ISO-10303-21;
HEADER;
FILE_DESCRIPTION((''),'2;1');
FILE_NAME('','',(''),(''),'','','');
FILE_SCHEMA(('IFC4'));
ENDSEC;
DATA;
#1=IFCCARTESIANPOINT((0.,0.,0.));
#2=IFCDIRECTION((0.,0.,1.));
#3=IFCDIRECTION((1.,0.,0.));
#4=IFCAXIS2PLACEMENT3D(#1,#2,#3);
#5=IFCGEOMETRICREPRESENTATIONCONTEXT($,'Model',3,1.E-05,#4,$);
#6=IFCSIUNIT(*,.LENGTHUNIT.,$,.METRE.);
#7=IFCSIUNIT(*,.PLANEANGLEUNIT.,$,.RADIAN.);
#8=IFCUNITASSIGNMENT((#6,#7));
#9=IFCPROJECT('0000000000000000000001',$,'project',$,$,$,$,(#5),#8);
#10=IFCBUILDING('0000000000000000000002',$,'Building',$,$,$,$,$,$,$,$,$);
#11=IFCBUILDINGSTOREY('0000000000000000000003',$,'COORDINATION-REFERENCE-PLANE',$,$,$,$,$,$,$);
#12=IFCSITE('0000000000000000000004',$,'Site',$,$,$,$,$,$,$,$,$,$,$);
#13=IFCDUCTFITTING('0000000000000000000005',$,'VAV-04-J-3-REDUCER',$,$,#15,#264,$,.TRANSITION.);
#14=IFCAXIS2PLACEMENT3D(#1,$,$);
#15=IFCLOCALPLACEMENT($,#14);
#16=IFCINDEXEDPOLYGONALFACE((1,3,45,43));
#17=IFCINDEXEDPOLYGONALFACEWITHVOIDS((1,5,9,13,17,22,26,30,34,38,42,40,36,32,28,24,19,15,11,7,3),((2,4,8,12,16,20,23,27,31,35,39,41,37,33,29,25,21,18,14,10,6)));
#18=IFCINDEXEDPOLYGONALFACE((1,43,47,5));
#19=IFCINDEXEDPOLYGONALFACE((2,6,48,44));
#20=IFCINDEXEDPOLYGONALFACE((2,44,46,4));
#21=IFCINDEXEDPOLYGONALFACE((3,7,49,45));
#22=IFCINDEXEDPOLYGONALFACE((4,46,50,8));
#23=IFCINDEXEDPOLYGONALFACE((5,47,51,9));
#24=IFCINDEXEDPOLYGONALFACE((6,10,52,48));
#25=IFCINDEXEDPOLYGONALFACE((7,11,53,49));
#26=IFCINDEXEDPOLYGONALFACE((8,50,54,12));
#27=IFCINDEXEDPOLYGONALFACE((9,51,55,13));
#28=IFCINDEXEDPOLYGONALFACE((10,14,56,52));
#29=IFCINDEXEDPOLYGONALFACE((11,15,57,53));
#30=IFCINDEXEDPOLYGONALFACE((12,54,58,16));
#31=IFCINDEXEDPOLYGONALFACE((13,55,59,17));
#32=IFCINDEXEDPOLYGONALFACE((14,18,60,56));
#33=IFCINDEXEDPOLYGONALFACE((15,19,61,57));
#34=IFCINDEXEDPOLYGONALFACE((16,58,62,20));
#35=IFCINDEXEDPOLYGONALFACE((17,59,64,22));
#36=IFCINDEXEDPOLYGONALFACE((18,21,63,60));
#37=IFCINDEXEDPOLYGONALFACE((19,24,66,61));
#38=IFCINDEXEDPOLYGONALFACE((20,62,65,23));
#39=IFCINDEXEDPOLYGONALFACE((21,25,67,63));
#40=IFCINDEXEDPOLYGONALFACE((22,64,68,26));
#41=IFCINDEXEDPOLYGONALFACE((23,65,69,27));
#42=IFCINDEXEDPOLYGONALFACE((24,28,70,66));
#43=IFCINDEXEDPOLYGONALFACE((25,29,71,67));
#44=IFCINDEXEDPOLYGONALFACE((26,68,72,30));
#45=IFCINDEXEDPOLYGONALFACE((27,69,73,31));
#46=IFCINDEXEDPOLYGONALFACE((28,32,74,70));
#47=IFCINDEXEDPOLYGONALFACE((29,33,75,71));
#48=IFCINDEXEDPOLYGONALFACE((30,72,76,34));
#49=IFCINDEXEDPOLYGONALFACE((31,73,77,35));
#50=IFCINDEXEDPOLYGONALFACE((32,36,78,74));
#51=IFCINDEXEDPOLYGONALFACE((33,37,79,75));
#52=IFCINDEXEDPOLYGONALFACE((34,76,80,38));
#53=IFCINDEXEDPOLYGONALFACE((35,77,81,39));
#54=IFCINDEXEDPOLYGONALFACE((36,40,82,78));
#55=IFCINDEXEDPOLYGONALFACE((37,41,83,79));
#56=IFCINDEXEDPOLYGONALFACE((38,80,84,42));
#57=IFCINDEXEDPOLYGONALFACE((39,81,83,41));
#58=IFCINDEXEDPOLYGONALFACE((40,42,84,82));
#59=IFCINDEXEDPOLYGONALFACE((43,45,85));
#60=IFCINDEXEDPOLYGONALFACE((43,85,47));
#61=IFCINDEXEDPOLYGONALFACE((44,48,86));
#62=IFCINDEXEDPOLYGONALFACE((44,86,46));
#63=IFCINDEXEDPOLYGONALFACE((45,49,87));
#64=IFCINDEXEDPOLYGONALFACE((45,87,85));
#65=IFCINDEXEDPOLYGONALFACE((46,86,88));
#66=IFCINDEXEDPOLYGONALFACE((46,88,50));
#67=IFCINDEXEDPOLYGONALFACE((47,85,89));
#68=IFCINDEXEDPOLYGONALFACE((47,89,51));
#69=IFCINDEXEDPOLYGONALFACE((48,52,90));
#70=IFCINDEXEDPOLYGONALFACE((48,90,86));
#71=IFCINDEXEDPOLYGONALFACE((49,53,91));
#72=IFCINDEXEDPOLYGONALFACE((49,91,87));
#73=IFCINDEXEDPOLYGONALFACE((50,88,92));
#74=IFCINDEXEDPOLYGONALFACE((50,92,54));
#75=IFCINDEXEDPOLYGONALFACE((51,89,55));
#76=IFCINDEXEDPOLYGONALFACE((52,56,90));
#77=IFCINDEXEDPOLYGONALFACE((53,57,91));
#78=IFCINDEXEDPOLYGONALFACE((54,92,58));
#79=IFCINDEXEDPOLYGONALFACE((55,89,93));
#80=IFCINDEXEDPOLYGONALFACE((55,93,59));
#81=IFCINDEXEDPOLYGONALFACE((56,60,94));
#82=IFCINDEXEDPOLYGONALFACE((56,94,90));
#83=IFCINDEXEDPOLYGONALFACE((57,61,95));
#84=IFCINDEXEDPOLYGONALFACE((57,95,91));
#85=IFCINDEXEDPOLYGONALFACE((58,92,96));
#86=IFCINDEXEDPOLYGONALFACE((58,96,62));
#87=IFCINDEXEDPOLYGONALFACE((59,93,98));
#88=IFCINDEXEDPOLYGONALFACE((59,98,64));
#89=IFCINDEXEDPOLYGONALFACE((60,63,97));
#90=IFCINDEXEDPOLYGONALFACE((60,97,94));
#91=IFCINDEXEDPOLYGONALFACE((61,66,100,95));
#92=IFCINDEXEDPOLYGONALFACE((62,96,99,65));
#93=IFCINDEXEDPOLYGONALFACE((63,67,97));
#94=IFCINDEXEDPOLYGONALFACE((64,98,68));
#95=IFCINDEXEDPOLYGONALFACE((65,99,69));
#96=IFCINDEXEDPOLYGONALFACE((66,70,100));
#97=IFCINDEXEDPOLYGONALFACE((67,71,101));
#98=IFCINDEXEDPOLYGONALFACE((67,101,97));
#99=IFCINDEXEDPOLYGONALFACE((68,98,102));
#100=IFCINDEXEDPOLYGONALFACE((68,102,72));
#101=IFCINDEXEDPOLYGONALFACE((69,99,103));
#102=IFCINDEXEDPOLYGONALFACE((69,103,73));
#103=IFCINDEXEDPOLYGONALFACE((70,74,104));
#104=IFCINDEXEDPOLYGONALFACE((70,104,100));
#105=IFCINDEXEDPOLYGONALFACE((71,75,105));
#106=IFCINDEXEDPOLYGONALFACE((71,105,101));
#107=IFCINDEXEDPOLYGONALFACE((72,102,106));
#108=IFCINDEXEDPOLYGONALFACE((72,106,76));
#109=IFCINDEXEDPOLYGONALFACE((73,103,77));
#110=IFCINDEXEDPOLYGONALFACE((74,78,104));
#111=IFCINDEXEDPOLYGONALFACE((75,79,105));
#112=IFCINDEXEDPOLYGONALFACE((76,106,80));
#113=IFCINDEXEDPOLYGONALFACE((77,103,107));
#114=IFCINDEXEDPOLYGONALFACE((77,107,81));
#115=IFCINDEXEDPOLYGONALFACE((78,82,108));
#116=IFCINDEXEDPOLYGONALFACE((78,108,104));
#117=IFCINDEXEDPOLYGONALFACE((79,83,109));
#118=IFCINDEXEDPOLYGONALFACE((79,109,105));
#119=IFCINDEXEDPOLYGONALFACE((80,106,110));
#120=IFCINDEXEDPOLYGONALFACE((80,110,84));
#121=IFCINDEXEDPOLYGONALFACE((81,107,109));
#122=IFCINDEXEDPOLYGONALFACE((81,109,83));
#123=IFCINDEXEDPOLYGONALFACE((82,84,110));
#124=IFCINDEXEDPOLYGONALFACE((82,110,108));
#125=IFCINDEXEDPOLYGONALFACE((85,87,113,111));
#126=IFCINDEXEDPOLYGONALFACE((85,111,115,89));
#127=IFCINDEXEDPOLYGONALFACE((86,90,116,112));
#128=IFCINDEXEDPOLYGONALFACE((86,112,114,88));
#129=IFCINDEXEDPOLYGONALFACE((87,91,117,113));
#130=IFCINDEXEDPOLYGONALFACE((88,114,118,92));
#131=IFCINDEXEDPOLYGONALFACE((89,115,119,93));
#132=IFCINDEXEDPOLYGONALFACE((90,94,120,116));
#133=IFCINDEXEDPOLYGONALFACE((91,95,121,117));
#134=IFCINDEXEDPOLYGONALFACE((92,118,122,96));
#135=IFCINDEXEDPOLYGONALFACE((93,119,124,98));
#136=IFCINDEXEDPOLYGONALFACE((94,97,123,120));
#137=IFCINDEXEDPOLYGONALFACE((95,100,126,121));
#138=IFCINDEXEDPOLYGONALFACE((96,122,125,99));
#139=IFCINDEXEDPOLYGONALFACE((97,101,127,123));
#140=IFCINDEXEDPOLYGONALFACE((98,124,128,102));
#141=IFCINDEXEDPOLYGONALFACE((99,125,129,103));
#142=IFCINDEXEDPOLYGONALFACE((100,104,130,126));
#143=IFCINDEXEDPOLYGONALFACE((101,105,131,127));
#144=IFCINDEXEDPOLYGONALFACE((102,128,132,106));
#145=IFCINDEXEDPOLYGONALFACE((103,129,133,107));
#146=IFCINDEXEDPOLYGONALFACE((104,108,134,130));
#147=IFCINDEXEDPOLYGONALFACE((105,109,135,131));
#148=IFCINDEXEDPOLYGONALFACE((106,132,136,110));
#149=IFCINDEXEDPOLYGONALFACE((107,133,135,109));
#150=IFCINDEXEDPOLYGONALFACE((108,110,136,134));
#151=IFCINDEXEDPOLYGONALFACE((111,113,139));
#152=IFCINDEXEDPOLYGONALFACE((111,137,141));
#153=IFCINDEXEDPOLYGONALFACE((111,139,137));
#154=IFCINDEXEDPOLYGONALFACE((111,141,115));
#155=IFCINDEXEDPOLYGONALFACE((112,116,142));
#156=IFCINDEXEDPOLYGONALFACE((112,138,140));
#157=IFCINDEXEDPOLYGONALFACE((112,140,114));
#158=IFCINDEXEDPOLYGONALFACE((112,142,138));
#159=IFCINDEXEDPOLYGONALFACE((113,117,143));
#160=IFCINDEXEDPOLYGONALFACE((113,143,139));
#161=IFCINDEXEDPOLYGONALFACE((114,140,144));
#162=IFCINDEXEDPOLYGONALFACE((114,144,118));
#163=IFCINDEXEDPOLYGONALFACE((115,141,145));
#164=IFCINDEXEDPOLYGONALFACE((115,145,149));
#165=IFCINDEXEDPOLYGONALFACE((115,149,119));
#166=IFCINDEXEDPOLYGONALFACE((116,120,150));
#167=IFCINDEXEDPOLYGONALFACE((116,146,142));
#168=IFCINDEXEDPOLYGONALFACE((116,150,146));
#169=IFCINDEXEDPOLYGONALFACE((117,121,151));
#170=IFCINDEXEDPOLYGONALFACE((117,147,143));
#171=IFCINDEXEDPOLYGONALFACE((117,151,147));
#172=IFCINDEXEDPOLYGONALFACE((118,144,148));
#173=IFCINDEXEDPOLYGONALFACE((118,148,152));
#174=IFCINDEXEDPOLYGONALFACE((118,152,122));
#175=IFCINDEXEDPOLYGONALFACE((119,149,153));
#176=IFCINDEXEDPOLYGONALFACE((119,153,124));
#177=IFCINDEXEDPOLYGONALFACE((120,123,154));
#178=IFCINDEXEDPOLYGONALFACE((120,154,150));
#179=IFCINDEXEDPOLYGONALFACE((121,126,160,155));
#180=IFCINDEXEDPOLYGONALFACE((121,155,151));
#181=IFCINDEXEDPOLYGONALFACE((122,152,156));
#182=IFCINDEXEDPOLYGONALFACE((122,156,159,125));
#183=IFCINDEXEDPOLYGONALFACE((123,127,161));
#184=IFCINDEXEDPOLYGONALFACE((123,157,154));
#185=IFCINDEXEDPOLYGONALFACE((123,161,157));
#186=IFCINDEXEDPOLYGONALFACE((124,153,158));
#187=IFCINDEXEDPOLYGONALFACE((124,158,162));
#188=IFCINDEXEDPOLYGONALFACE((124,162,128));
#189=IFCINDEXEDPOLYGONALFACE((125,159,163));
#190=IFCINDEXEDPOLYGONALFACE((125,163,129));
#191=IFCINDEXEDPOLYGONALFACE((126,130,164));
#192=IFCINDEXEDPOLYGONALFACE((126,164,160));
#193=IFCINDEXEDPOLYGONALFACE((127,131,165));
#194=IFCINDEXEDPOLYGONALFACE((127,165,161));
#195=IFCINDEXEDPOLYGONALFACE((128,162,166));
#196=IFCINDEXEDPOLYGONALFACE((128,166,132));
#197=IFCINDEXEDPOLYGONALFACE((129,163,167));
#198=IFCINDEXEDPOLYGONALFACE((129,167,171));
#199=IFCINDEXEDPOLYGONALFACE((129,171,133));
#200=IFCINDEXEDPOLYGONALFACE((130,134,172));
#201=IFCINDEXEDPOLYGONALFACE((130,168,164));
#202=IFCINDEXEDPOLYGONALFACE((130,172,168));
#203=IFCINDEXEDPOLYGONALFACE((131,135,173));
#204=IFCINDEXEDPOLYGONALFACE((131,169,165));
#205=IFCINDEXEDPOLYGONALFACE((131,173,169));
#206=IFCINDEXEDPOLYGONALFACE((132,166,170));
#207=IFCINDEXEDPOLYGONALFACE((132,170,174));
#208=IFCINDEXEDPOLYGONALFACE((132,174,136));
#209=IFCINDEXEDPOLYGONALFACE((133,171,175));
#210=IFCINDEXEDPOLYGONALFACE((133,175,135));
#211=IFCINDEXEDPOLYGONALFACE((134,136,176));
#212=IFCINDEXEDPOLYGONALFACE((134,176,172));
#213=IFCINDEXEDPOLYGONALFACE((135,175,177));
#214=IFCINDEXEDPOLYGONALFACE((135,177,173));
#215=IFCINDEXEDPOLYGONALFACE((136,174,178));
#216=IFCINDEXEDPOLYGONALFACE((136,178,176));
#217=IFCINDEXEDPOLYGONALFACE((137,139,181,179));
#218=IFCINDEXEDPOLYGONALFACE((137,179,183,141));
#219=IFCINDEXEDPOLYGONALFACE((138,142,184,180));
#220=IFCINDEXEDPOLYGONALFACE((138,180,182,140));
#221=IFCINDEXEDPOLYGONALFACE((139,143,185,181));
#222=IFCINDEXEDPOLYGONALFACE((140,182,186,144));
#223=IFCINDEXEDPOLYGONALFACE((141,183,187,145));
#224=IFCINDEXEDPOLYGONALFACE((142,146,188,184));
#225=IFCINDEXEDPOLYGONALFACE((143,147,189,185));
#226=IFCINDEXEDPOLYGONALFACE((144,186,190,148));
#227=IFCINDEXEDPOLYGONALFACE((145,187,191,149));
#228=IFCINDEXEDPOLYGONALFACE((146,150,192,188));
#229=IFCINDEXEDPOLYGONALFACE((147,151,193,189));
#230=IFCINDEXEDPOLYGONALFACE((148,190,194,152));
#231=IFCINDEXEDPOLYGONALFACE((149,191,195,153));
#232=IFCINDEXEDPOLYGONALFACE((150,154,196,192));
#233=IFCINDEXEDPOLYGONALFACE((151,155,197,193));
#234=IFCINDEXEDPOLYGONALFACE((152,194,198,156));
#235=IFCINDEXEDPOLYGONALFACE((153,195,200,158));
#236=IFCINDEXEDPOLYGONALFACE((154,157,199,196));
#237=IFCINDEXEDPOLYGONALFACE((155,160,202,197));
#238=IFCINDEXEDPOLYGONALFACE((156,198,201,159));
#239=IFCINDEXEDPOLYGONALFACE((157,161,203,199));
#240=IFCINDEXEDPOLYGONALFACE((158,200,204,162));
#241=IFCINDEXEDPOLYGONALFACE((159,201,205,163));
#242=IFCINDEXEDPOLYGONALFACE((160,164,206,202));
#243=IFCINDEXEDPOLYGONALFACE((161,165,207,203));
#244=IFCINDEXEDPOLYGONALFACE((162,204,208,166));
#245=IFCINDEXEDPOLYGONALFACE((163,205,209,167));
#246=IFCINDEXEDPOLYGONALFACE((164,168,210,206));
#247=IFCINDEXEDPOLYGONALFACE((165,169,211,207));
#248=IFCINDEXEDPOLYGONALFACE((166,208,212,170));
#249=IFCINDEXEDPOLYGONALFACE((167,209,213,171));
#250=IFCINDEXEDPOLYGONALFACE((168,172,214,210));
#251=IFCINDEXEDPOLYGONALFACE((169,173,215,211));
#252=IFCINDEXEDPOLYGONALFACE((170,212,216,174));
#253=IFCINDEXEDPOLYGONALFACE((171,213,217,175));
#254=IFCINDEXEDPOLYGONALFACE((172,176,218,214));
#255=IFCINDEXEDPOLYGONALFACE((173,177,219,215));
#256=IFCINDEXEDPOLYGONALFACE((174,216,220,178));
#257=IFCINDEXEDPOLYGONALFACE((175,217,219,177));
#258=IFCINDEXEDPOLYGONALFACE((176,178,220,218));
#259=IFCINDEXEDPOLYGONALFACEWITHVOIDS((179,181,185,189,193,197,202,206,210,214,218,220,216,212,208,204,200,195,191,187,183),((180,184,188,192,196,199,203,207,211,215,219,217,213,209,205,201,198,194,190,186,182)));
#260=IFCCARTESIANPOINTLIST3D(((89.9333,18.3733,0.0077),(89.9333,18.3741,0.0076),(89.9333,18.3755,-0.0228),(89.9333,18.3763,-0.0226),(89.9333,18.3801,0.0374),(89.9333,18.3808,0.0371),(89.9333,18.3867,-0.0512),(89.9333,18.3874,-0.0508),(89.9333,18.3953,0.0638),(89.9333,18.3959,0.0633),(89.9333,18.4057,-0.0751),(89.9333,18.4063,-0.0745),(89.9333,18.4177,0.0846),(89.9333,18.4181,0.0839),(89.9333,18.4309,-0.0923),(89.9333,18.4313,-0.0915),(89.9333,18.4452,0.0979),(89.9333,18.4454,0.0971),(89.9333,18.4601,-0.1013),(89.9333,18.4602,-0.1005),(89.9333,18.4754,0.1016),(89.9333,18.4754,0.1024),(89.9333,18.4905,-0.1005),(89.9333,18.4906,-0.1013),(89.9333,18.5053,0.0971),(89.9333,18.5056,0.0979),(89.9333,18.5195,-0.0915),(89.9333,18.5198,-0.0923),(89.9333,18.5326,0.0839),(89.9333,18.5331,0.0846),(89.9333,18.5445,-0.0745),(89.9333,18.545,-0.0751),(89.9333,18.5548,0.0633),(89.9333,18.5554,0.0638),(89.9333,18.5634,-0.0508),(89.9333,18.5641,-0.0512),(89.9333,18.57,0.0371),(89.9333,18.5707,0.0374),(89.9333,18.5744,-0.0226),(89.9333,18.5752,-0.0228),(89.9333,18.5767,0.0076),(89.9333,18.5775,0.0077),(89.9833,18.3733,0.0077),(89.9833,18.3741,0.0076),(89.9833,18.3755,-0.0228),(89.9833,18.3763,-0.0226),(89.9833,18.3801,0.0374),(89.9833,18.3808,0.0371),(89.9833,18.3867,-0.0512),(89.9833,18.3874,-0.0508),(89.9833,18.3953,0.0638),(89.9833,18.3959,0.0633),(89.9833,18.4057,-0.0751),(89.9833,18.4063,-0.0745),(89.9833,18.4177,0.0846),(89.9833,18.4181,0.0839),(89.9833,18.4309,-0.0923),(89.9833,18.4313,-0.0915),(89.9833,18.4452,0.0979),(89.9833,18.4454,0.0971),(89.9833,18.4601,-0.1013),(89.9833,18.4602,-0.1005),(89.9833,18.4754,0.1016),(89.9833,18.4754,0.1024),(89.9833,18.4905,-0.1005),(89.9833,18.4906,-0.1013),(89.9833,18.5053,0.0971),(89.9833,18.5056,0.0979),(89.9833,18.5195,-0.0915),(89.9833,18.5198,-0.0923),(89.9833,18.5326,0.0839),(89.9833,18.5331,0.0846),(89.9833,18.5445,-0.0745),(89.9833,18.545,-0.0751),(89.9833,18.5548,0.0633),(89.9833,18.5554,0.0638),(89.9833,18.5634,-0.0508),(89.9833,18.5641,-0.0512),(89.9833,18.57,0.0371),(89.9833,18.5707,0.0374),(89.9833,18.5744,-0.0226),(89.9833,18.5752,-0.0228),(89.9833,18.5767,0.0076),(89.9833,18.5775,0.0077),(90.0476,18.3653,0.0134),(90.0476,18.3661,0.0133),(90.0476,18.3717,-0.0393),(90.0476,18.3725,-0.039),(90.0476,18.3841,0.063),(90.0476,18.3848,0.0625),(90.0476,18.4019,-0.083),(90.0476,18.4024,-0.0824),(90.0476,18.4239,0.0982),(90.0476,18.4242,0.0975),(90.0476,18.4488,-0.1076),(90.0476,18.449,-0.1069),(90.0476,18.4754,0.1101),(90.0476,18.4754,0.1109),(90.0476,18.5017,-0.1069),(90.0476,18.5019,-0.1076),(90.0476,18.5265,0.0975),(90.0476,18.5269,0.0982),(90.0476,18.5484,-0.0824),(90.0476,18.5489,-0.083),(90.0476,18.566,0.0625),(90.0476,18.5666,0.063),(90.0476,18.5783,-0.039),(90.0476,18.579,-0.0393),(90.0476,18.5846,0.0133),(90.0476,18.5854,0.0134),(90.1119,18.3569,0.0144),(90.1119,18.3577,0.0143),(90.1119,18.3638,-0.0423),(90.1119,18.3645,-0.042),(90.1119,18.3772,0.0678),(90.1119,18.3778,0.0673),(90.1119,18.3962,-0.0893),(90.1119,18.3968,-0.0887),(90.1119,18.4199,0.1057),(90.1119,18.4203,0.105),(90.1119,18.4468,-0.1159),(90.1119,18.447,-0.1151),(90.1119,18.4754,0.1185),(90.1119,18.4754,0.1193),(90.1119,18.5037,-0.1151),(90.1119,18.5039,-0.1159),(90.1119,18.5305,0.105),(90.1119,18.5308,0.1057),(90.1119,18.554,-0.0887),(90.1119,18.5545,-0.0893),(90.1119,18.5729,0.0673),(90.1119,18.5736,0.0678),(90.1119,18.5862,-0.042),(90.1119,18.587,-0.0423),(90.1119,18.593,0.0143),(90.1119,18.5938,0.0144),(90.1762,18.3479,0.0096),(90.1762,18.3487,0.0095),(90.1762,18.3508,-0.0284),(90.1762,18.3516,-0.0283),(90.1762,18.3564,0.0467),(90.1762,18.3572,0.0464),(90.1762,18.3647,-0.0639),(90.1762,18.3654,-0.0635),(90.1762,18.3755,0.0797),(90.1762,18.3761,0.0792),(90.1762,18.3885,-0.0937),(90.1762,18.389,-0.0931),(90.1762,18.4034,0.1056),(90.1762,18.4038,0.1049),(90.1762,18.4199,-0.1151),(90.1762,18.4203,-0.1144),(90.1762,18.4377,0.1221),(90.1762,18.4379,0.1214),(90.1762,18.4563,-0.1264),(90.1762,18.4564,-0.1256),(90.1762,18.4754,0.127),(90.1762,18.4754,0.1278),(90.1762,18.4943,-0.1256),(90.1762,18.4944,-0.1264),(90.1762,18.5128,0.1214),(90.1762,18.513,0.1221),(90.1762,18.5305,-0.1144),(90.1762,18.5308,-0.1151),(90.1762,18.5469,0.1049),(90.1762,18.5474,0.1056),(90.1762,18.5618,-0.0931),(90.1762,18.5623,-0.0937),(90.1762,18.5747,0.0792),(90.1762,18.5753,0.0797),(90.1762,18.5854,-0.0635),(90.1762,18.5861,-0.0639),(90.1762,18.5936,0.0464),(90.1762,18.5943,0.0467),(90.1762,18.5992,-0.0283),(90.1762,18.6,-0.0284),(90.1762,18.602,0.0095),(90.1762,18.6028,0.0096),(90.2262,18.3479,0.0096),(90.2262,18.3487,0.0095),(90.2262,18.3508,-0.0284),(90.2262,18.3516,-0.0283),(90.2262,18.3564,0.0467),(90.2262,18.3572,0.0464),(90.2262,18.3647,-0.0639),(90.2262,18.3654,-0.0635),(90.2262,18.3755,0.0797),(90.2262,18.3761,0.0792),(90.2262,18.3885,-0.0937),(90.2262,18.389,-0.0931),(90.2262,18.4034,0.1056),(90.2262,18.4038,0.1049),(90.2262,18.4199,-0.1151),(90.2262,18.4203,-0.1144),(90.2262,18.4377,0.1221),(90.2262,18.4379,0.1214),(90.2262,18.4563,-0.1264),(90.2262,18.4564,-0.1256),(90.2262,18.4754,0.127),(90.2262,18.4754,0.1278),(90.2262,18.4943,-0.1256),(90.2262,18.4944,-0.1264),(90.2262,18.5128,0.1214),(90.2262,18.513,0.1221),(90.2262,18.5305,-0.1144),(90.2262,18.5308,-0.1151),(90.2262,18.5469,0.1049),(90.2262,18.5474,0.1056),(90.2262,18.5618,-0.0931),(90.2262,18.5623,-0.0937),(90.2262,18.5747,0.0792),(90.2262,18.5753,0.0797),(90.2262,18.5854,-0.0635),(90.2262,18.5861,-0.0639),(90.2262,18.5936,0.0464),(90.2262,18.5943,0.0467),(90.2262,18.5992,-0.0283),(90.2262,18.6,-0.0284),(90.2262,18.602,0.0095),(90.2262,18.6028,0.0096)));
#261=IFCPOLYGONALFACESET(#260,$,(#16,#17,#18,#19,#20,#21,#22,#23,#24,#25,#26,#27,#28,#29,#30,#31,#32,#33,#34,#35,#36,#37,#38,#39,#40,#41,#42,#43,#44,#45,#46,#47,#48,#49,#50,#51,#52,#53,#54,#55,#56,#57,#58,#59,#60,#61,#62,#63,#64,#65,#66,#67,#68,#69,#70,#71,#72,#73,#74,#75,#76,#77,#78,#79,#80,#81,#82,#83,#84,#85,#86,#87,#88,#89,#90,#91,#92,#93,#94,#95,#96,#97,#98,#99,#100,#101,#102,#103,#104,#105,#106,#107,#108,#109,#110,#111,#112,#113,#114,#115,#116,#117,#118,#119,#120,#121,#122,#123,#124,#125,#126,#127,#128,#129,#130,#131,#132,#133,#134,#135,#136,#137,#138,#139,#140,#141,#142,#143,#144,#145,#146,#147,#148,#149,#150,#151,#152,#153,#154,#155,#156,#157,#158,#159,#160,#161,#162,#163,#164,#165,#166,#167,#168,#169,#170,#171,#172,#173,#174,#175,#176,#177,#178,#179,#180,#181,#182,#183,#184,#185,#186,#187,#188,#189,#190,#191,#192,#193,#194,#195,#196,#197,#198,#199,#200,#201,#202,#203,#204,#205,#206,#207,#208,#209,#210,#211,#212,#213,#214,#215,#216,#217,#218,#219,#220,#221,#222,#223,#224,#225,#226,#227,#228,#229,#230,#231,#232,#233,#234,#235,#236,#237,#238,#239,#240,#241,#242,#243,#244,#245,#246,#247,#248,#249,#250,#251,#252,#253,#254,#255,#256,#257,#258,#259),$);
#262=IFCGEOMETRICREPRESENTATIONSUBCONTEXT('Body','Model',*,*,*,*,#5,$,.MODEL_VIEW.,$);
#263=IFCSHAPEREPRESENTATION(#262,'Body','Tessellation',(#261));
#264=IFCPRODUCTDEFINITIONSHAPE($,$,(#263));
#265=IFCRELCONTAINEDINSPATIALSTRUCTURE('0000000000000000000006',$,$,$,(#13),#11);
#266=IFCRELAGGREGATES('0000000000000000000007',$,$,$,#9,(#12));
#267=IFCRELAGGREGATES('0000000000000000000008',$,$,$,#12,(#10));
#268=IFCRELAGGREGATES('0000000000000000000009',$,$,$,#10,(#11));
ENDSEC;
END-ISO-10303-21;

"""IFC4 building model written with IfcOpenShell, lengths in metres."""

from ifc_helpers import new_model, entity, si_unit, frame, origin_with_axes, place, context, subcontext, project, spatial, element, save


model = new_model("IFC4")

# Units and contexts
model_context = context("Model", 3, precision=1e-05, world=origin_with_axes())
body_context_1 = subcontext(model_context, "Body", "Model", "MODEL_VIEW")
ifc_project = project(units=[si_unit("LENGTHUNIT", "METRE"), si_unit("PLANEANGLEUNIT", "RADIAN")], contexts=[model_context])

# Site, building, storey
site = spatial("IfcSite", under=ifc_project, Name="Site")
building = spatial("IfcBuilding", under=site, Name="Building")
storey = spatial("IfcBuildingStorey", under=building, Name="COORDINATION-REFERENCE-PLANE")

# Duct fitting
for number, where, z_axis, x_axis, name in (
    (1, (90.2262, 18.4754, 0.0), (0.0, -1.0, 0.0), (0.0, 0.0, 1.0), "VAV-04-J-3-REDUCER"),
):
    element("IfcDuctFitting", number, at=place(None, frame(where, z_axis=z_axis, x_axis=x_axis)), inside=storey, Name=name, PredefinedType="TRANSITION", context=body_context_1, shape_type="SweptSolid", body=[
        entity("IfcRevolvedAreaSolid", entity("IfcArbitraryClosedProfileDef", "AREA", None, entity("IfcPolyline", [entity("IfcCartesianPoint", [0.1278, 0.0]), entity("IfcCartesianPoint", [0.1278, 0.05]), entity("IfcCartesianPoint", [0.1024, 0.2429]), entity("IfcCartesianPoint", [0.1024, 0.2929]), entity("IfcCartesianPoint", [0.1016, 0.2929]), entity("IfcCartesianPoint", [0.1016, 0.2429]), entity("IfcCartesianPoint", [0.127, 0.05]), entity("IfcCartesianPoint", [0.127, 0.0]), entity("IfcCartesianPoint", [0.1278, 0.0])])), entity("IfcAxis2Placement3D", entity("IfcCartesianPoint", [0.0, 0.0, 0.0])), entity("IfcAxis1Placement", entity("IfcCartesianPoint", [0.0, 0.0, 0.0]), entity("IfcDirection", [0.0, 1.0, 0.0])), 6.283185),
    ])

save(model, "model.ifc")
